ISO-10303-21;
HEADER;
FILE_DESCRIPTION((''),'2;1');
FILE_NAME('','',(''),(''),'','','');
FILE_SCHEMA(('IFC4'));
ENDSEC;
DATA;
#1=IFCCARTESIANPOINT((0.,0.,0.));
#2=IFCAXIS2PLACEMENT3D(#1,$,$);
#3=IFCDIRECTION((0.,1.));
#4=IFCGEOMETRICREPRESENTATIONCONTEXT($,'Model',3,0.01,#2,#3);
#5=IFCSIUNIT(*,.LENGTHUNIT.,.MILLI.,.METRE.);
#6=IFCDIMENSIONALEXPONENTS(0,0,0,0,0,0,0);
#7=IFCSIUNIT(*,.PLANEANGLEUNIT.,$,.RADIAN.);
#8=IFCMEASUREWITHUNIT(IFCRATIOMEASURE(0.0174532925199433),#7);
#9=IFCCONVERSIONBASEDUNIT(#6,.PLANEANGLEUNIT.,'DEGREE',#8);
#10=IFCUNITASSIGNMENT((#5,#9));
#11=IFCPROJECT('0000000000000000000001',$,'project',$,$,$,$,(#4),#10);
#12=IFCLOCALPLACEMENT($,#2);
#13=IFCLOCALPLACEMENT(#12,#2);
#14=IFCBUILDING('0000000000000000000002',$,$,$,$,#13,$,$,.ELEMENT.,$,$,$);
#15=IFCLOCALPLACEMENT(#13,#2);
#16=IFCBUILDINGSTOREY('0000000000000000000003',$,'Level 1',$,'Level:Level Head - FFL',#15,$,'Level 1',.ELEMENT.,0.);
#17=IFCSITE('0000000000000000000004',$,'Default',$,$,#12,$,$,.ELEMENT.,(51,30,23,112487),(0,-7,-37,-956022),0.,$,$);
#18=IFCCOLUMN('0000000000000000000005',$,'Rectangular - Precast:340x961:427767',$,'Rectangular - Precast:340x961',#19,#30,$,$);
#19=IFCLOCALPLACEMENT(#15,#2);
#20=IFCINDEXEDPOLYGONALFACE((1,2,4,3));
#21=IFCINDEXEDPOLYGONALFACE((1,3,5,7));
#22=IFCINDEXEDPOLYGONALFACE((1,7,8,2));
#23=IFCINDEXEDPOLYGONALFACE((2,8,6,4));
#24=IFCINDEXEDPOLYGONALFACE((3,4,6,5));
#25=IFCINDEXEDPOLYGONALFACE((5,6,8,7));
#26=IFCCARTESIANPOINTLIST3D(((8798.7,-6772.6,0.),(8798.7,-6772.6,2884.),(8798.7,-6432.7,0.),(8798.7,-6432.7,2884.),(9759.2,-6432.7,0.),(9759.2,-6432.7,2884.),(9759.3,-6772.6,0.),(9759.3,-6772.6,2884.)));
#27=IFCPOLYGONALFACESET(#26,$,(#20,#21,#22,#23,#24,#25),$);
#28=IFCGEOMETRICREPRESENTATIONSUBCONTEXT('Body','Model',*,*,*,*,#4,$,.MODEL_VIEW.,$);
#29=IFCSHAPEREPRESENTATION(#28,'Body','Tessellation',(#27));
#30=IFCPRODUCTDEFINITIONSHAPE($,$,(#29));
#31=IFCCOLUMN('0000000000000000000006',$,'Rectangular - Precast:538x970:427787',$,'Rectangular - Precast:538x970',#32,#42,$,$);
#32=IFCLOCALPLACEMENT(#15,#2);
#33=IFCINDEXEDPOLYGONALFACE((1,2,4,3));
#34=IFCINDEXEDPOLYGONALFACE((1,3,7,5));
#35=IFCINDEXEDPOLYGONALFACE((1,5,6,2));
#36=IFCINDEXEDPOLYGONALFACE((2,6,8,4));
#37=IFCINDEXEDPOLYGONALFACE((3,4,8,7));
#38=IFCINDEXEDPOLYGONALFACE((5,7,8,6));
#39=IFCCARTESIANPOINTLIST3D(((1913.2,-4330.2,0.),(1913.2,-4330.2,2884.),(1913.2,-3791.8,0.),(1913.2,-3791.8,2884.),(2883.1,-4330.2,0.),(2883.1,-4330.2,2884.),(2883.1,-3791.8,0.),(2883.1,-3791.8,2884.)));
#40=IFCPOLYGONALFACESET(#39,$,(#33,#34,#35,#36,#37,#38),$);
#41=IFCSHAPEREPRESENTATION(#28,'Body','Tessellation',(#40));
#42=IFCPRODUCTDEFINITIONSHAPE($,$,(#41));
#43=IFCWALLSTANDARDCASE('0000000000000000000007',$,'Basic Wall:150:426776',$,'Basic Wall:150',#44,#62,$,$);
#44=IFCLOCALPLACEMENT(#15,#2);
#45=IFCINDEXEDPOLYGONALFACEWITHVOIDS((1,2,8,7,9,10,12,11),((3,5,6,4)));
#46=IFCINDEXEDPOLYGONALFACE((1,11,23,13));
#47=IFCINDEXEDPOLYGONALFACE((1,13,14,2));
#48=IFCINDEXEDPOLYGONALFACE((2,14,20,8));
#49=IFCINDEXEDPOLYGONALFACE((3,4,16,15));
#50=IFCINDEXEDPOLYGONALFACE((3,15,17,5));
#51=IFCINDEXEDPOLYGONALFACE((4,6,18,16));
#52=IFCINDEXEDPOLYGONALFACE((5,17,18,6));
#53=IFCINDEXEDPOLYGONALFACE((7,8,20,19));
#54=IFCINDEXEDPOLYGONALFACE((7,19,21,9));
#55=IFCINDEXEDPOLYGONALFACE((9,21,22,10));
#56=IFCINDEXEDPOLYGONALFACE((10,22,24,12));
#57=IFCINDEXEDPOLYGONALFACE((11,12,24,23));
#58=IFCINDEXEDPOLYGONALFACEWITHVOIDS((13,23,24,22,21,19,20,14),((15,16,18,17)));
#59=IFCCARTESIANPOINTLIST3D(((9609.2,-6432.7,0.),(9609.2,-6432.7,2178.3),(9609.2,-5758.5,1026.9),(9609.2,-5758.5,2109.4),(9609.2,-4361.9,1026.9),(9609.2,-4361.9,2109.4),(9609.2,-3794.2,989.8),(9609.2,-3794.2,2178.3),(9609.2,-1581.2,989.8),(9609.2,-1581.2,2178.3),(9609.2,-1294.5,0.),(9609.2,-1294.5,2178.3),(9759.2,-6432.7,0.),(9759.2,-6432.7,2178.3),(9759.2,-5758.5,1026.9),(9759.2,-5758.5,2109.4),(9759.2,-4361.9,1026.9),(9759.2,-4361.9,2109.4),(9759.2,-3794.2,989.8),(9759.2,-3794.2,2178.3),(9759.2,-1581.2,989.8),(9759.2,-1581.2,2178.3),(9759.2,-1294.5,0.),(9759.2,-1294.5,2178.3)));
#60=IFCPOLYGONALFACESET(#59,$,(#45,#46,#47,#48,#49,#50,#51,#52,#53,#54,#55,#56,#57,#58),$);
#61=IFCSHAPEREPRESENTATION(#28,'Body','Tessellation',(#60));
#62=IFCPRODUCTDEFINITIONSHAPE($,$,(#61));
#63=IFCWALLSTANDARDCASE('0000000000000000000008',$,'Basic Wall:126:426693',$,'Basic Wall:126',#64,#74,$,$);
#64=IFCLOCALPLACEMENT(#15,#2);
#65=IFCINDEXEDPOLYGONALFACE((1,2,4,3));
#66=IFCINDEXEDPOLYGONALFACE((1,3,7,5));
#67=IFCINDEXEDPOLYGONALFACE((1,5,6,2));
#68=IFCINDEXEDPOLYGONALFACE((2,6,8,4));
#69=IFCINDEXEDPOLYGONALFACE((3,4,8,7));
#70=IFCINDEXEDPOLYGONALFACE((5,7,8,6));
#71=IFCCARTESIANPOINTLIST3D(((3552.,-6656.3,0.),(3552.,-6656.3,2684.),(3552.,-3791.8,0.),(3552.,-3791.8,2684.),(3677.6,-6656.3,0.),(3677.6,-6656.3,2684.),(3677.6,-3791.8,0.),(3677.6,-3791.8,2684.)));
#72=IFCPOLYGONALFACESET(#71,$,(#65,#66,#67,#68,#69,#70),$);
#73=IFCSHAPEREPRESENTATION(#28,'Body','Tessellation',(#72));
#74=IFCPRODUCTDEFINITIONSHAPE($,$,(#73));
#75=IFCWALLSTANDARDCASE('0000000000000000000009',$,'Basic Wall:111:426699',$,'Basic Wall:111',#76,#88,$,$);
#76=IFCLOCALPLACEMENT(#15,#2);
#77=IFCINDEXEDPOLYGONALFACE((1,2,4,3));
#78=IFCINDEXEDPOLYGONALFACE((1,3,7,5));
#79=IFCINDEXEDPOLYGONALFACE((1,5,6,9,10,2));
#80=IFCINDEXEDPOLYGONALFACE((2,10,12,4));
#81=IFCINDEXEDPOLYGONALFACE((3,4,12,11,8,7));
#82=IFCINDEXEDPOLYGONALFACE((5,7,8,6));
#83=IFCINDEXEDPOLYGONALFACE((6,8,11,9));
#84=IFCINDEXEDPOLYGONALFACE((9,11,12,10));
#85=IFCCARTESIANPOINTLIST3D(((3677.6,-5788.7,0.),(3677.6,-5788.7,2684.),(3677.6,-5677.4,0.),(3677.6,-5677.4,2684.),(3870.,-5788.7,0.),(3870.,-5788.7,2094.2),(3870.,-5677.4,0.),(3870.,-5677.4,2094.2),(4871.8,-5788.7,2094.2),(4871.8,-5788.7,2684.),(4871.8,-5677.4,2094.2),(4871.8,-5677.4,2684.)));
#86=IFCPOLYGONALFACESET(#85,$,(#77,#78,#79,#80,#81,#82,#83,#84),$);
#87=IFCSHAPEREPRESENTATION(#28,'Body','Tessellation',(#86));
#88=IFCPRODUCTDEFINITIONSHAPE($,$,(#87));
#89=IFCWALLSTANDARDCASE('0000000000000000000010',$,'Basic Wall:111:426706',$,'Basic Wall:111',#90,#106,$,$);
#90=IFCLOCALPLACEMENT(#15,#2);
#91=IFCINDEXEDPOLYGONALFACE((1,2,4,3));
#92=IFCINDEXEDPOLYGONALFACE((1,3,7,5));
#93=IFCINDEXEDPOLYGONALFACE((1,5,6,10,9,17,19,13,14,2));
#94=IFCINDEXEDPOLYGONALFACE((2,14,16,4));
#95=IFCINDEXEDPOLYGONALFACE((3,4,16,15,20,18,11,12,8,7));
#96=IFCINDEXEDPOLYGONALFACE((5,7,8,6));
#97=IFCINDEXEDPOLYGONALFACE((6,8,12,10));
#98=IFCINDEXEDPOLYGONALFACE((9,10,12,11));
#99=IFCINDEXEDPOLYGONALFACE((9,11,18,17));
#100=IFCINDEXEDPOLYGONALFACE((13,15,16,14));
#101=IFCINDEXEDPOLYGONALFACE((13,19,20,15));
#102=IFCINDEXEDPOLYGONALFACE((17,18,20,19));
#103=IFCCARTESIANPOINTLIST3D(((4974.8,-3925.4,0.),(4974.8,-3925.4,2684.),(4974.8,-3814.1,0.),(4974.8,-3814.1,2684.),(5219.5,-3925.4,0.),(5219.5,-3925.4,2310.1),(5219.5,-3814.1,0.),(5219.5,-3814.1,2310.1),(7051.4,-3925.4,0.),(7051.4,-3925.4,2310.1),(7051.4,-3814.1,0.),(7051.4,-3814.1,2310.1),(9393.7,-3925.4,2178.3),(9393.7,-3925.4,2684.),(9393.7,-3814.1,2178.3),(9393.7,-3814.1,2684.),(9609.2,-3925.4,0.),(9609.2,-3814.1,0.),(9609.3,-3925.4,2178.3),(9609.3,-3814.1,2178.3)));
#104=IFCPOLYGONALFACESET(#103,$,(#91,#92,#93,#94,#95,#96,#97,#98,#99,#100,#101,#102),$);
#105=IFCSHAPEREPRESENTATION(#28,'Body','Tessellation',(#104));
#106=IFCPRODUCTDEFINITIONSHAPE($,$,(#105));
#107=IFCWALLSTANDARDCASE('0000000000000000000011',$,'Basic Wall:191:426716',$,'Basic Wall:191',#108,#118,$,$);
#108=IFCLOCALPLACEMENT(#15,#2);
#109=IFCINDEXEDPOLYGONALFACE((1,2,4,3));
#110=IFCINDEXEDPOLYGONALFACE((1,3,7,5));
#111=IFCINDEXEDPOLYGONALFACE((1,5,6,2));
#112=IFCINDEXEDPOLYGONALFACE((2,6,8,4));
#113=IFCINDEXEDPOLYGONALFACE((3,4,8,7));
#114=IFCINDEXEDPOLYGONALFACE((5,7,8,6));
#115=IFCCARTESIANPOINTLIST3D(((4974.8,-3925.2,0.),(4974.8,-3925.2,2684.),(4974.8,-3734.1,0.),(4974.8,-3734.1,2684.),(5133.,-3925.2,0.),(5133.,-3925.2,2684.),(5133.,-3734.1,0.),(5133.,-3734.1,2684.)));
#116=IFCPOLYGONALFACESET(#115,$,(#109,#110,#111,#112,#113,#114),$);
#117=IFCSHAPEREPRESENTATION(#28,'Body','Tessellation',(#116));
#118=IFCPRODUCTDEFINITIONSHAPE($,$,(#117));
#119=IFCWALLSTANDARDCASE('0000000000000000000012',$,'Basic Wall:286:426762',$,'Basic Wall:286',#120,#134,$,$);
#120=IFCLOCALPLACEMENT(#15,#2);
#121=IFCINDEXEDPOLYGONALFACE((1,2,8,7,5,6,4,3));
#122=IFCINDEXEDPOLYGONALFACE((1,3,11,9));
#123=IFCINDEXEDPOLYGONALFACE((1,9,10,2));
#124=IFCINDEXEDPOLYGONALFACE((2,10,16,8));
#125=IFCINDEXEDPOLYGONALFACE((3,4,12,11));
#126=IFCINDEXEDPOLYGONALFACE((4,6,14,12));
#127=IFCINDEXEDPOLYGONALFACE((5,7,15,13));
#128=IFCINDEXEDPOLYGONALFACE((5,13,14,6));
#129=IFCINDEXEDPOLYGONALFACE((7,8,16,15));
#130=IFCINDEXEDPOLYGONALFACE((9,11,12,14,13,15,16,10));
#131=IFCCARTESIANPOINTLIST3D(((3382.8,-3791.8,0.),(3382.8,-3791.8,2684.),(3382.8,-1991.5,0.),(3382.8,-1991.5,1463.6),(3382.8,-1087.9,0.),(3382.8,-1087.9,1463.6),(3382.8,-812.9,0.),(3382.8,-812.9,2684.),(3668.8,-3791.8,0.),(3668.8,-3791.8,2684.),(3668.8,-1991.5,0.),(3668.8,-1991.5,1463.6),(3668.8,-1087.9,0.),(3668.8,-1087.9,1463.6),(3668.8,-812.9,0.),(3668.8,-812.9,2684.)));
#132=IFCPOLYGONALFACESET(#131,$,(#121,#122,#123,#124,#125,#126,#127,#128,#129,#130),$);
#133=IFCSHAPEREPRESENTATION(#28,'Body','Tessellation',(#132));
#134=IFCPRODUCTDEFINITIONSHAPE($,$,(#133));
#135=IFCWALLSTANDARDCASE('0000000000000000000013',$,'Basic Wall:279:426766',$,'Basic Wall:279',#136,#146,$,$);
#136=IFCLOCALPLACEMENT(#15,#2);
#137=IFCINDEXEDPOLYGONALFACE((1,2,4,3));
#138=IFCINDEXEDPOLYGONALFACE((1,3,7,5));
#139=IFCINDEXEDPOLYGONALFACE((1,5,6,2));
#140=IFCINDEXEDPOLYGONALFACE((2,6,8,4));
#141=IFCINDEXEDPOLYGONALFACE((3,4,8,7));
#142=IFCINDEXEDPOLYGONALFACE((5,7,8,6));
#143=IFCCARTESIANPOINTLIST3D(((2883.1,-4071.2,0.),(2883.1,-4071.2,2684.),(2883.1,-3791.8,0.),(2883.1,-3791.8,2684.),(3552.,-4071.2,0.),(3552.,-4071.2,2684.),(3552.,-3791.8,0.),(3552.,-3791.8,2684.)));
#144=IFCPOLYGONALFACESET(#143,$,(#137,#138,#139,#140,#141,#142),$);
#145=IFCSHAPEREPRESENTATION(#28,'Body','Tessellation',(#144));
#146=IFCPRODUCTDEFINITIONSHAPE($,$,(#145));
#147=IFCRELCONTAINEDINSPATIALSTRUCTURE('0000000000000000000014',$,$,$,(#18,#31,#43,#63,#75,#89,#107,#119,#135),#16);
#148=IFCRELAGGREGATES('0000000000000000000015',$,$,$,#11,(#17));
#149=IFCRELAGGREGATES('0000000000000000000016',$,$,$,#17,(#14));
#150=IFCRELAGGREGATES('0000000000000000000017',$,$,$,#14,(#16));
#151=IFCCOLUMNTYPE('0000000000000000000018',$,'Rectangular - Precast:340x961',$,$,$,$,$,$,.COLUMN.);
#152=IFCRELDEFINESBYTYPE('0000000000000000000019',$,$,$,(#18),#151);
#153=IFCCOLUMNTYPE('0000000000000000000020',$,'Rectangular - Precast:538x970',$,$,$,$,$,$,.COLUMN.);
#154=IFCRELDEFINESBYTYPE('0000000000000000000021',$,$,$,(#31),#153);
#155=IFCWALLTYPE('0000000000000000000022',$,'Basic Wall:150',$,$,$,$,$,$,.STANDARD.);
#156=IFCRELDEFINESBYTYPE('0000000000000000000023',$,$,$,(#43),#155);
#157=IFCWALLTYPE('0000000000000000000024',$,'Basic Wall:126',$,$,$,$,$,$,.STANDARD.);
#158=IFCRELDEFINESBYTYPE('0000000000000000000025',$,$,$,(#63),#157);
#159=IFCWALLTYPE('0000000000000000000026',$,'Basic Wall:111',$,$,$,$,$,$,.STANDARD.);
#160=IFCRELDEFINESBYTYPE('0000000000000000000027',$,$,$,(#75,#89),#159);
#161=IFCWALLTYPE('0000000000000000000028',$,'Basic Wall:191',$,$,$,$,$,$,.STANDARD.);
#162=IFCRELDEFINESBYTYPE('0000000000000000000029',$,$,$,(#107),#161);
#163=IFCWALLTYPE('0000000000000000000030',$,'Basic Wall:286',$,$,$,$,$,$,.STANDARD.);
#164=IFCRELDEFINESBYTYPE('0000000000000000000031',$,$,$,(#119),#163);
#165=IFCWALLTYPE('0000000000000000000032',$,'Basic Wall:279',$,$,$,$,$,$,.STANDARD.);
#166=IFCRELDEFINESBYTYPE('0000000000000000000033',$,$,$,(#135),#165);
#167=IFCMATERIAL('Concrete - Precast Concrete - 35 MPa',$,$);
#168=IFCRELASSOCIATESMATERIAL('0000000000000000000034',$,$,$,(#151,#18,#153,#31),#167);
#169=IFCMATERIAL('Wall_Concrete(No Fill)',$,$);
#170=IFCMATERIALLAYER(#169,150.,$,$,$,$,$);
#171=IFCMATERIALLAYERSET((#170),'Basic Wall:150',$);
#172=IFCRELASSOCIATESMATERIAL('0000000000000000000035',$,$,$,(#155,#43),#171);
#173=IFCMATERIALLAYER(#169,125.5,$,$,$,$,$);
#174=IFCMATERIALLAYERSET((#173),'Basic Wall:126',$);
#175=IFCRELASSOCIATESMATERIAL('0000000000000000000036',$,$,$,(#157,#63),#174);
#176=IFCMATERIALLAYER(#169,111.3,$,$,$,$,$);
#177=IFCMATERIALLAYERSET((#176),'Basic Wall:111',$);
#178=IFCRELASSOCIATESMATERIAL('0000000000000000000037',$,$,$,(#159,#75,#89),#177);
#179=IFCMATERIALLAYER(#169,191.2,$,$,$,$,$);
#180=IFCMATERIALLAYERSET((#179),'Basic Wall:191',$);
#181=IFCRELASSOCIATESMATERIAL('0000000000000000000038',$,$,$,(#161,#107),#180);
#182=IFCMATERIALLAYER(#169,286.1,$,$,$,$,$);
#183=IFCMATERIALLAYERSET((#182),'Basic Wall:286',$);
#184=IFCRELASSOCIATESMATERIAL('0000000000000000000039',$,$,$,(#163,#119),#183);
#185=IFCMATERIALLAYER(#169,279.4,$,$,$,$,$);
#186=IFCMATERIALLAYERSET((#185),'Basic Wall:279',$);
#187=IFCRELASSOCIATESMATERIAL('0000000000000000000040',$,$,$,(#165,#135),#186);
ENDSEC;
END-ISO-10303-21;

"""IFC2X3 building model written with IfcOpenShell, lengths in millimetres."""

from ifc_helpers import new_model, entity, si_unit, converted_unit, direction, frame, frame_2d, origin, origin_2d_with_axis, place, context, subcontext, project, spatial, rectangle, extrude, source, transform, mapped, material, layer, layer_set, layer_usage, type_object, type_shapes, element, save


model = new_model("IFC2X3")

# Units and contexts
model_context = context("Model", 3, precision=0.01, world=origin(), true_north=direction((0.0, 1.0)))
body_context = subcontext(model_context, "Body", "Model", "MODEL_VIEW")
ifc_project = project(units=[si_unit("LENGTHUNIT", "METRE", prefix="MILLI"), converted_unit("PLANEANGLEUNIT", "DEGREE", entity("IfcRatioMeasure", 0.0174532925199433), si_unit("PLANEANGLEUNIT", "RADIAN"), dimensions=[0, 0, 0, 0, 0, 0, 0])], contexts=[model_context])

# Site, building, storey
site_placement = place(None, origin())
site = spatial("IfcSite", under=ifc_project, at=site_placement, Name="Default", CompositionType="ELEMENT", RefLatitude=(51, 30, 23, 112487), RefLongitude=(0, -7, -37, -956022), RefElevation=0.0)
building_placement = place(site_placement, origin())
building = spatial("IfcBuilding", under=site, at=building_placement, CompositionType="ELEMENT")
storey_placement = place(building_placement, origin())
storey = spatial("IfcBuildingStorey", under=building, at=storey_placement, Name="Level 1", ObjectType="Level:Level Head - FFL", LongName="Level 1", CompositionType="ELEMENT", Elevation=0.0)

# Columns
ifc_material_1 = material(Name="Concrete - Precast Concrete - 35 MPa")
column_type_1 = type_object("IfcColumnType", Name="Rectangular - Precast:340x961", PredefinedType="COLUMN", material=ifc_material_1)
shared_shape_1 = source(origin(), body_context, "Body", "SweptSolid", [
    extrude(rectangle(XDim=960.5, YDim=340.0, at=frame_2d((0.0, 0.0), x_axis=(1.0, 0.0))), frame((0.0, 0.0, 0.0), z_axis=(0.0, 0.0, 1.0), x_axis=(0.0, -1.0, 0.0)), (0.0, 0.0, 1.0), 2884.0),
])
type_shapes(column_type_1, [shared_shape_1])
column_1_placement = place(storey_placement, frame((9279.0, -6602.7, 0.0), z_axis=(0.0, 0.0, 1.0), x_axis=(-0.000004, 1.0, 0.0)))
element("IfcColumn", 1, at=column_1_placement, inside=storey, type_object=column_type_1, material=ifc_material_1, Name="Rectangular - Precast:340x961:427767", ObjectType="Rectangular - Precast:340x961", context=body_context, shape_type="MappedRepresentation", body=[
    mapped(shared_shape_1, transform((0.0, 0.0, 0.0), scale=1.0)),
])
column_type_2 = type_object("IfcColumnType", Name="Rectangular - Precast:538x970", PredefinedType="COLUMN", material=ifc_material_1)
shared_shape_2 = source(origin(), body_context, "Body", "SweptSolid", [
    extrude(rectangle(XDim=969.9, YDim=538.4, at=frame_2d((0.0, 0.0), x_axis=(1.0, 0.0))), frame((0.0, 0.0, 0.0), z_axis=(0.0, 0.0, 1.0), x_axis=(0.0, -1.0, 0.0)), (0.0, 0.0, 1.0), 2884.0),
])
type_shapes(column_type_2, [shared_shape_2])
column_2_placement = place(storey_placement, frame((2398.2, -4061.0, 0.0), z_axis=(0.0, 0.0, 1.0), x_axis=(-0.000004, 1.0, 0.0)))
element("IfcColumn", 2, at=column_2_placement, inside=storey, type_object=column_type_2, material=ifc_material_1, Name="Rectangular - Precast:538x970:427787", ObjectType="Rectangular - Precast:538x970", context=body_context, shape_type="MappedRepresentation", body=[
    mapped(shared_shape_2, transform((0.0, 0.0, 0.0), scale=1.0)),
])

# Wall, openings
ifc_material_2 = material(Name="Wall_Concrete(No Fill)")
ifc_layer_1 = layer(ifc_material_2, 150.0)
ifc_layer_set_1 = layer_set([ifc_layer_1], Name="Basic Wall:150")
wall_type_1 = type_object("IfcWallType", Name="Basic Wall:150", PredefinedType="STANDARD", material=ifc_layer_set_1)
ifc_layer_usage_1 = layer_usage(ifc_layer_set_1, "AXIS2", "NEGATIVE", 75.0)
wall_1_placement = place(storey_placement, frame((9684.2, -6432.7, 0.0), z_axis=(0.0, 0.0, 1.0), x_axis=(0.0, 1.0, 0.0)))
wall_1 = element("IfcWallStandardCase", 3, at=wall_1_placement, inside=storey, type_object=wall_type_1, material=ifc_layer_usage_1, Name="Basic Wall:150:426776", ObjectType="Basic Wall:150", context=body_context, shape_type="SweptSolid", body=[
    extrude(rectangle(XDim=5138.2, YDim=150.0, at=frame_2d((2569.1, 0.0), x_axis=(-1.0, 0.0))), origin(), (0.0, 0.0, 1.0), 2178.3),
])
opening_1_placement = place(wall_1_placement, origin())
element("IfcOpeningElement", 4, at=opening_1_placement, cuts=wall_1, ObjectType="Opening", context=body_context, shape_type="SweptSolid", body=[
    extrude(rectangle(XDim=705.7, YDim=5138.2, at=frame_2d((0.0, 0.0), x_axis=(1.0, 0.0))), frame((2569.1, -75.0, 2531.1), z_axis=(0.0, 1.0, 0.0), x_axis=(0.0, 0.0, -1.0)), (0.0, 0.0, 1.0), 150.0),
])
opening_2_placement = place(wall_1_placement, origin())
element("IfcOpeningElement", 5, at=opening_2_placement, cuts=wall_1, ObjectType="Opening", context=body_context, shape_type="SweptSolid", body=[
    extrude(rectangle(XDim=1082.5, YDim=1396.7, at=frame_2d((0.0, 0.0), x_axis=(1.0, 0.0))), frame((1372.5, -75.0, 1568.2), z_axis=(0.0, 1.0, 0.0), x_axis=(0.0, 0.0, -1.0)), (0.0, 0.0, 1.0), 150.0),
])
opening_3_placement = place(wall_1_placement, origin())
element("IfcOpeningElement", 6, at=opening_3_placement, cuts=wall_1, ObjectType="Opening", context=body_context, shape_type="SweptSolid", body=[
    extrude(rectangle(XDim=1199.2, YDim=2213.0, at=origin_2d_with_axis()), frame((3745.0, -75.0, 1589.4), z_axis=(0.0, 1.0, 0.0), x_axis=(0.0, 0.0, -1.0)), (0.0, 0.0, 1.0), 150.0),
])

# Wall
ifc_layer_2 = layer(ifc_material_2, 125.5)
ifc_layer_set_2 = layer_set([ifc_layer_2], Name="Basic Wall:126")
ifc_layer_usage_2 = layer_usage(ifc_layer_set_2, "AXIS2", "NEGATIVE", 62.8)
wall_type_2 = type_object("IfcWallType", Name="Basic Wall:126", PredefinedType="STANDARD", material=ifc_layer_set_2)
wall_2_placement = place(storey_placement, frame((3614.8, -6656.3, 0.0), z_axis=(0.0, 0.0, 1.0), x_axis=(0.0, 1.0, 0.0)))
element("IfcWallStandardCase", 7, at=wall_2_placement, inside=storey, type_object=wall_type_2, material=ifc_layer_usage_2, Name="Basic Wall:126:426693", ObjectType="Basic Wall:126", context=body_context, shape_type="SweptSolid", body=[
    extrude(rectangle(XDim=2864.5, YDim=125.5, at=frame_2d((1432.3, 0.0), x_axis=(-1.0, 0.0))), origin(), (0.0, 0.0, 1.0), 2684.0),
])

# Wall, opening
ifc_layer_3 = layer(ifc_material_2, 111.3)
ifc_layer_set_3 = layer_set([ifc_layer_3], Name="Basic Wall:111")
ifc_layer_usage_3 = layer_usage(ifc_layer_set_3, "AXIS2", "NEGATIVE", 55.7)
wall_type_3 = type_object("IfcWallType", Name="Basic Wall:111", PredefinedType="STANDARD", material=ifc_layer_set_3)
wall_3_placement = place(storey_placement, frame((3677.6, -5733.0, 0.0)))
wall_3 = element("IfcWallStandardCase", 8, at=wall_3_placement, inside=storey, type_object=wall_type_3, material=ifc_layer_usage_3, Name="Basic Wall:111:426699", ObjectType="Basic Wall:111", context=body_context, shape_type="SweptSolid", body=[
    extrude(rectangle(XDim=1194.2, YDim=111.3, at=frame_2d((597.1, 0.0), x_axis=(-1.0, 0.0))), origin(), (0.0, 0.0, 1.0), 2684.0),
])
opening_4_placement = place(wall_3_placement, origin())
element("IfcOpeningElement", 9, at=opening_4_placement, cuts=wall_3, ObjectType="Opening", context=body_context, shape_type="SweptSolid", body=[
    extrude(rectangle(XDim=2094.2, YDim=1017.4, at=frame_2d((0.0, 0.0), x_axis=(1.0, 0.0))), frame((701.1, -55.7, 1047.1), z_axis=(0.0, 1.0, 0.0), x_axis=(0.0, 0.0, -1.0)), (0.0, 0.0, 1.0), 111.3),
])

# Wall, openings
ifc_layer_usage_4 = layer_usage(ifc_layer_set_3, "AXIS2", "NEGATIVE", 55.7)
wall_4_placement = place(storey_placement, frame((4974.8, -3869.8, 0.0)))
wall_4 = element("IfcWallStandardCase", 10, at=wall_4_placement, inside=storey, type_object=wall_type_3, material=ifc_layer_usage_4, Name="Basic Wall:111:426706", ObjectType="Basic Wall:111", context=body_context, shape_type="SweptSolid", body=[
    extrude(rectangle(XDim=4634.5, YDim=111.3, at=frame_2d((2317.2, 0.0), x_axis=(-1.0, 0.0))), origin(), (0.0, 0.0, 1.0), 2684.0),
])
opening_5_placement = place(wall_4_placement, origin())
element("IfcOpeningElement", 11, at=opening_5_placement, cuts=wall_4, ObjectType="Opening", context=body_context, shape_type="SweptSolid", body=[
    extrude(rectangle(XDim=705.7, YDim=215.6, at=frame_2d((0.0, 0.0), x_axis=(1.0, 0.0))), frame((4526.7, -55.7, 2531.1), z_axis=(0.0, 1.0, 0.0), x_axis=(0.0, 0.0, -1.0)), (0.0, 0.0, 1.0), 111.3),
])
opening_6_placement = place(wall_4_placement, origin())
element("IfcOpeningElement", 12, at=opening_6_placement, cuts=wall_4, ObjectType="Opening", context=body_context, shape_type="SweptSolid", body=[
    extrude(rectangle(XDim=2310.1, YDim=1831.8, at=frame_2d((0.0, 0.0), x_axis=(1.0, 0.0))), frame((1160.7, -55.7, 1155.0), z_axis=(0.0, 1.0, 0.0), x_axis=(0.0, 0.0, -1.0)), (0.0, 0.0, 1.0), 111.3),
])

# Wall
ifc_layer_4 = layer(ifc_material_2, 191.2)
ifc_layer_set_4 = layer_set([ifc_layer_4], Name="Basic Wall:191")
ifc_layer_usage_5 = layer_usage(ifc_layer_set_4, "AXIS2", "NEGATIVE", 95.6)
wall_type_4 = type_object("IfcWallType", Name="Basic Wall:191", PredefinedType="STANDARD", material=ifc_layer_set_4)
wall_5_placement = place(storey_placement, frame((4974.8, -3829.7, 0.0)))
element("IfcWallStandardCase", 13, at=wall_5_placement, inside=storey, type_object=wall_type_4, material=ifc_layer_usage_5, Name="Basic Wall:191:426716", ObjectType="Basic Wall:191", context=body_context, shape_type="SweptSolid", body=[
    extrude(rectangle(XDim=158.2, YDim=191.2, at=frame_2d((79.1, 0.0), x_axis=(-1.0, 0.0))), origin(), (0.0, 0.0, 1.0), 2684.0),
])

# Wall, opening
ifc_layer_5 = layer(ifc_material_2, 286.1)
ifc_layer_set_5 = layer_set([ifc_layer_5], Name="Basic Wall:286")
ifc_layer_usage_6 = layer_usage(ifc_layer_set_5, "AXIS2", "NEGATIVE", 143.0)
wall_type_5 = type_object("IfcWallType", Name="Basic Wall:286", PredefinedType="STANDARD", material=ifc_layer_set_5)
wall_6_placement = place(storey_placement, frame((3525.8, -3791.8, 0.0), z_axis=(0.0, 0.0, 1.0), x_axis=(0.0, 1.0, 0.0)))
wall_6 = element("IfcWallStandardCase", 14, at=wall_6_placement, inside=storey, type_object=wall_type_5, material=ifc_layer_usage_6, Name="Basic Wall:286:426762", ObjectType="Basic Wall:286", context=body_context, shape_type="SweptSolid", body=[
    extrude(rectangle(XDim=2978.9, YDim=286.1, at=frame_2d((1489.5, 0.0), x_axis=(-1.0, 0.0))), origin(), (0.0, 0.0, 1.0), 2684.0),
])
opening_7_placement = place(wall_6_placement, origin())
element("IfcOpeningElement", 15, at=opening_7_placement, cuts=wall_6, ObjectType="Opening", context=body_context, shape_type="SweptSolid", body=[
    extrude(rectangle(XDim=1463.6, YDim=903.6, at=frame_2d((0.0, 0.0), x_axis=(1.0, 0.0))), frame((2252.1, -143.0, 731.8), z_axis=(0.0, 1.0, 0.0), x_axis=(0.0, 0.0, -1.0)), (0.0, 0.0, 1.0), 286.1),
])

# Wall
ifc_layer_6 = layer(ifc_material_2, 279.4)
ifc_layer_set_6 = layer_set([ifc_layer_6], Name="Basic Wall:279")
ifc_layer_usage_7 = layer_usage(ifc_layer_set_6, "AXIS2", "NEGATIVE", 139.7)
wall_type_6 = type_object("IfcWallType", Name="Basic Wall:279", PredefinedType="STANDARD", material=ifc_layer_set_6)
wall_7_placement = place(storey_placement, frame((2883.1, -3931.5, 0.0)))
element("IfcWallStandardCase", 16, at=wall_7_placement, inside=storey, type_object=wall_type_6, material=ifc_layer_usage_7, Name="Basic Wall:279:426766", ObjectType="Basic Wall:279", context=body_context, shape_type="SweptSolid", body=[
    extrude(rectangle(XDim=668.9, YDim=279.4, at=frame_2d((334.5, 0.0), x_axis=(-1.0, 0.0))), origin(), (0.0, 0.0, 1.0), 2684.0),
])

save(model, "model.ifc")
